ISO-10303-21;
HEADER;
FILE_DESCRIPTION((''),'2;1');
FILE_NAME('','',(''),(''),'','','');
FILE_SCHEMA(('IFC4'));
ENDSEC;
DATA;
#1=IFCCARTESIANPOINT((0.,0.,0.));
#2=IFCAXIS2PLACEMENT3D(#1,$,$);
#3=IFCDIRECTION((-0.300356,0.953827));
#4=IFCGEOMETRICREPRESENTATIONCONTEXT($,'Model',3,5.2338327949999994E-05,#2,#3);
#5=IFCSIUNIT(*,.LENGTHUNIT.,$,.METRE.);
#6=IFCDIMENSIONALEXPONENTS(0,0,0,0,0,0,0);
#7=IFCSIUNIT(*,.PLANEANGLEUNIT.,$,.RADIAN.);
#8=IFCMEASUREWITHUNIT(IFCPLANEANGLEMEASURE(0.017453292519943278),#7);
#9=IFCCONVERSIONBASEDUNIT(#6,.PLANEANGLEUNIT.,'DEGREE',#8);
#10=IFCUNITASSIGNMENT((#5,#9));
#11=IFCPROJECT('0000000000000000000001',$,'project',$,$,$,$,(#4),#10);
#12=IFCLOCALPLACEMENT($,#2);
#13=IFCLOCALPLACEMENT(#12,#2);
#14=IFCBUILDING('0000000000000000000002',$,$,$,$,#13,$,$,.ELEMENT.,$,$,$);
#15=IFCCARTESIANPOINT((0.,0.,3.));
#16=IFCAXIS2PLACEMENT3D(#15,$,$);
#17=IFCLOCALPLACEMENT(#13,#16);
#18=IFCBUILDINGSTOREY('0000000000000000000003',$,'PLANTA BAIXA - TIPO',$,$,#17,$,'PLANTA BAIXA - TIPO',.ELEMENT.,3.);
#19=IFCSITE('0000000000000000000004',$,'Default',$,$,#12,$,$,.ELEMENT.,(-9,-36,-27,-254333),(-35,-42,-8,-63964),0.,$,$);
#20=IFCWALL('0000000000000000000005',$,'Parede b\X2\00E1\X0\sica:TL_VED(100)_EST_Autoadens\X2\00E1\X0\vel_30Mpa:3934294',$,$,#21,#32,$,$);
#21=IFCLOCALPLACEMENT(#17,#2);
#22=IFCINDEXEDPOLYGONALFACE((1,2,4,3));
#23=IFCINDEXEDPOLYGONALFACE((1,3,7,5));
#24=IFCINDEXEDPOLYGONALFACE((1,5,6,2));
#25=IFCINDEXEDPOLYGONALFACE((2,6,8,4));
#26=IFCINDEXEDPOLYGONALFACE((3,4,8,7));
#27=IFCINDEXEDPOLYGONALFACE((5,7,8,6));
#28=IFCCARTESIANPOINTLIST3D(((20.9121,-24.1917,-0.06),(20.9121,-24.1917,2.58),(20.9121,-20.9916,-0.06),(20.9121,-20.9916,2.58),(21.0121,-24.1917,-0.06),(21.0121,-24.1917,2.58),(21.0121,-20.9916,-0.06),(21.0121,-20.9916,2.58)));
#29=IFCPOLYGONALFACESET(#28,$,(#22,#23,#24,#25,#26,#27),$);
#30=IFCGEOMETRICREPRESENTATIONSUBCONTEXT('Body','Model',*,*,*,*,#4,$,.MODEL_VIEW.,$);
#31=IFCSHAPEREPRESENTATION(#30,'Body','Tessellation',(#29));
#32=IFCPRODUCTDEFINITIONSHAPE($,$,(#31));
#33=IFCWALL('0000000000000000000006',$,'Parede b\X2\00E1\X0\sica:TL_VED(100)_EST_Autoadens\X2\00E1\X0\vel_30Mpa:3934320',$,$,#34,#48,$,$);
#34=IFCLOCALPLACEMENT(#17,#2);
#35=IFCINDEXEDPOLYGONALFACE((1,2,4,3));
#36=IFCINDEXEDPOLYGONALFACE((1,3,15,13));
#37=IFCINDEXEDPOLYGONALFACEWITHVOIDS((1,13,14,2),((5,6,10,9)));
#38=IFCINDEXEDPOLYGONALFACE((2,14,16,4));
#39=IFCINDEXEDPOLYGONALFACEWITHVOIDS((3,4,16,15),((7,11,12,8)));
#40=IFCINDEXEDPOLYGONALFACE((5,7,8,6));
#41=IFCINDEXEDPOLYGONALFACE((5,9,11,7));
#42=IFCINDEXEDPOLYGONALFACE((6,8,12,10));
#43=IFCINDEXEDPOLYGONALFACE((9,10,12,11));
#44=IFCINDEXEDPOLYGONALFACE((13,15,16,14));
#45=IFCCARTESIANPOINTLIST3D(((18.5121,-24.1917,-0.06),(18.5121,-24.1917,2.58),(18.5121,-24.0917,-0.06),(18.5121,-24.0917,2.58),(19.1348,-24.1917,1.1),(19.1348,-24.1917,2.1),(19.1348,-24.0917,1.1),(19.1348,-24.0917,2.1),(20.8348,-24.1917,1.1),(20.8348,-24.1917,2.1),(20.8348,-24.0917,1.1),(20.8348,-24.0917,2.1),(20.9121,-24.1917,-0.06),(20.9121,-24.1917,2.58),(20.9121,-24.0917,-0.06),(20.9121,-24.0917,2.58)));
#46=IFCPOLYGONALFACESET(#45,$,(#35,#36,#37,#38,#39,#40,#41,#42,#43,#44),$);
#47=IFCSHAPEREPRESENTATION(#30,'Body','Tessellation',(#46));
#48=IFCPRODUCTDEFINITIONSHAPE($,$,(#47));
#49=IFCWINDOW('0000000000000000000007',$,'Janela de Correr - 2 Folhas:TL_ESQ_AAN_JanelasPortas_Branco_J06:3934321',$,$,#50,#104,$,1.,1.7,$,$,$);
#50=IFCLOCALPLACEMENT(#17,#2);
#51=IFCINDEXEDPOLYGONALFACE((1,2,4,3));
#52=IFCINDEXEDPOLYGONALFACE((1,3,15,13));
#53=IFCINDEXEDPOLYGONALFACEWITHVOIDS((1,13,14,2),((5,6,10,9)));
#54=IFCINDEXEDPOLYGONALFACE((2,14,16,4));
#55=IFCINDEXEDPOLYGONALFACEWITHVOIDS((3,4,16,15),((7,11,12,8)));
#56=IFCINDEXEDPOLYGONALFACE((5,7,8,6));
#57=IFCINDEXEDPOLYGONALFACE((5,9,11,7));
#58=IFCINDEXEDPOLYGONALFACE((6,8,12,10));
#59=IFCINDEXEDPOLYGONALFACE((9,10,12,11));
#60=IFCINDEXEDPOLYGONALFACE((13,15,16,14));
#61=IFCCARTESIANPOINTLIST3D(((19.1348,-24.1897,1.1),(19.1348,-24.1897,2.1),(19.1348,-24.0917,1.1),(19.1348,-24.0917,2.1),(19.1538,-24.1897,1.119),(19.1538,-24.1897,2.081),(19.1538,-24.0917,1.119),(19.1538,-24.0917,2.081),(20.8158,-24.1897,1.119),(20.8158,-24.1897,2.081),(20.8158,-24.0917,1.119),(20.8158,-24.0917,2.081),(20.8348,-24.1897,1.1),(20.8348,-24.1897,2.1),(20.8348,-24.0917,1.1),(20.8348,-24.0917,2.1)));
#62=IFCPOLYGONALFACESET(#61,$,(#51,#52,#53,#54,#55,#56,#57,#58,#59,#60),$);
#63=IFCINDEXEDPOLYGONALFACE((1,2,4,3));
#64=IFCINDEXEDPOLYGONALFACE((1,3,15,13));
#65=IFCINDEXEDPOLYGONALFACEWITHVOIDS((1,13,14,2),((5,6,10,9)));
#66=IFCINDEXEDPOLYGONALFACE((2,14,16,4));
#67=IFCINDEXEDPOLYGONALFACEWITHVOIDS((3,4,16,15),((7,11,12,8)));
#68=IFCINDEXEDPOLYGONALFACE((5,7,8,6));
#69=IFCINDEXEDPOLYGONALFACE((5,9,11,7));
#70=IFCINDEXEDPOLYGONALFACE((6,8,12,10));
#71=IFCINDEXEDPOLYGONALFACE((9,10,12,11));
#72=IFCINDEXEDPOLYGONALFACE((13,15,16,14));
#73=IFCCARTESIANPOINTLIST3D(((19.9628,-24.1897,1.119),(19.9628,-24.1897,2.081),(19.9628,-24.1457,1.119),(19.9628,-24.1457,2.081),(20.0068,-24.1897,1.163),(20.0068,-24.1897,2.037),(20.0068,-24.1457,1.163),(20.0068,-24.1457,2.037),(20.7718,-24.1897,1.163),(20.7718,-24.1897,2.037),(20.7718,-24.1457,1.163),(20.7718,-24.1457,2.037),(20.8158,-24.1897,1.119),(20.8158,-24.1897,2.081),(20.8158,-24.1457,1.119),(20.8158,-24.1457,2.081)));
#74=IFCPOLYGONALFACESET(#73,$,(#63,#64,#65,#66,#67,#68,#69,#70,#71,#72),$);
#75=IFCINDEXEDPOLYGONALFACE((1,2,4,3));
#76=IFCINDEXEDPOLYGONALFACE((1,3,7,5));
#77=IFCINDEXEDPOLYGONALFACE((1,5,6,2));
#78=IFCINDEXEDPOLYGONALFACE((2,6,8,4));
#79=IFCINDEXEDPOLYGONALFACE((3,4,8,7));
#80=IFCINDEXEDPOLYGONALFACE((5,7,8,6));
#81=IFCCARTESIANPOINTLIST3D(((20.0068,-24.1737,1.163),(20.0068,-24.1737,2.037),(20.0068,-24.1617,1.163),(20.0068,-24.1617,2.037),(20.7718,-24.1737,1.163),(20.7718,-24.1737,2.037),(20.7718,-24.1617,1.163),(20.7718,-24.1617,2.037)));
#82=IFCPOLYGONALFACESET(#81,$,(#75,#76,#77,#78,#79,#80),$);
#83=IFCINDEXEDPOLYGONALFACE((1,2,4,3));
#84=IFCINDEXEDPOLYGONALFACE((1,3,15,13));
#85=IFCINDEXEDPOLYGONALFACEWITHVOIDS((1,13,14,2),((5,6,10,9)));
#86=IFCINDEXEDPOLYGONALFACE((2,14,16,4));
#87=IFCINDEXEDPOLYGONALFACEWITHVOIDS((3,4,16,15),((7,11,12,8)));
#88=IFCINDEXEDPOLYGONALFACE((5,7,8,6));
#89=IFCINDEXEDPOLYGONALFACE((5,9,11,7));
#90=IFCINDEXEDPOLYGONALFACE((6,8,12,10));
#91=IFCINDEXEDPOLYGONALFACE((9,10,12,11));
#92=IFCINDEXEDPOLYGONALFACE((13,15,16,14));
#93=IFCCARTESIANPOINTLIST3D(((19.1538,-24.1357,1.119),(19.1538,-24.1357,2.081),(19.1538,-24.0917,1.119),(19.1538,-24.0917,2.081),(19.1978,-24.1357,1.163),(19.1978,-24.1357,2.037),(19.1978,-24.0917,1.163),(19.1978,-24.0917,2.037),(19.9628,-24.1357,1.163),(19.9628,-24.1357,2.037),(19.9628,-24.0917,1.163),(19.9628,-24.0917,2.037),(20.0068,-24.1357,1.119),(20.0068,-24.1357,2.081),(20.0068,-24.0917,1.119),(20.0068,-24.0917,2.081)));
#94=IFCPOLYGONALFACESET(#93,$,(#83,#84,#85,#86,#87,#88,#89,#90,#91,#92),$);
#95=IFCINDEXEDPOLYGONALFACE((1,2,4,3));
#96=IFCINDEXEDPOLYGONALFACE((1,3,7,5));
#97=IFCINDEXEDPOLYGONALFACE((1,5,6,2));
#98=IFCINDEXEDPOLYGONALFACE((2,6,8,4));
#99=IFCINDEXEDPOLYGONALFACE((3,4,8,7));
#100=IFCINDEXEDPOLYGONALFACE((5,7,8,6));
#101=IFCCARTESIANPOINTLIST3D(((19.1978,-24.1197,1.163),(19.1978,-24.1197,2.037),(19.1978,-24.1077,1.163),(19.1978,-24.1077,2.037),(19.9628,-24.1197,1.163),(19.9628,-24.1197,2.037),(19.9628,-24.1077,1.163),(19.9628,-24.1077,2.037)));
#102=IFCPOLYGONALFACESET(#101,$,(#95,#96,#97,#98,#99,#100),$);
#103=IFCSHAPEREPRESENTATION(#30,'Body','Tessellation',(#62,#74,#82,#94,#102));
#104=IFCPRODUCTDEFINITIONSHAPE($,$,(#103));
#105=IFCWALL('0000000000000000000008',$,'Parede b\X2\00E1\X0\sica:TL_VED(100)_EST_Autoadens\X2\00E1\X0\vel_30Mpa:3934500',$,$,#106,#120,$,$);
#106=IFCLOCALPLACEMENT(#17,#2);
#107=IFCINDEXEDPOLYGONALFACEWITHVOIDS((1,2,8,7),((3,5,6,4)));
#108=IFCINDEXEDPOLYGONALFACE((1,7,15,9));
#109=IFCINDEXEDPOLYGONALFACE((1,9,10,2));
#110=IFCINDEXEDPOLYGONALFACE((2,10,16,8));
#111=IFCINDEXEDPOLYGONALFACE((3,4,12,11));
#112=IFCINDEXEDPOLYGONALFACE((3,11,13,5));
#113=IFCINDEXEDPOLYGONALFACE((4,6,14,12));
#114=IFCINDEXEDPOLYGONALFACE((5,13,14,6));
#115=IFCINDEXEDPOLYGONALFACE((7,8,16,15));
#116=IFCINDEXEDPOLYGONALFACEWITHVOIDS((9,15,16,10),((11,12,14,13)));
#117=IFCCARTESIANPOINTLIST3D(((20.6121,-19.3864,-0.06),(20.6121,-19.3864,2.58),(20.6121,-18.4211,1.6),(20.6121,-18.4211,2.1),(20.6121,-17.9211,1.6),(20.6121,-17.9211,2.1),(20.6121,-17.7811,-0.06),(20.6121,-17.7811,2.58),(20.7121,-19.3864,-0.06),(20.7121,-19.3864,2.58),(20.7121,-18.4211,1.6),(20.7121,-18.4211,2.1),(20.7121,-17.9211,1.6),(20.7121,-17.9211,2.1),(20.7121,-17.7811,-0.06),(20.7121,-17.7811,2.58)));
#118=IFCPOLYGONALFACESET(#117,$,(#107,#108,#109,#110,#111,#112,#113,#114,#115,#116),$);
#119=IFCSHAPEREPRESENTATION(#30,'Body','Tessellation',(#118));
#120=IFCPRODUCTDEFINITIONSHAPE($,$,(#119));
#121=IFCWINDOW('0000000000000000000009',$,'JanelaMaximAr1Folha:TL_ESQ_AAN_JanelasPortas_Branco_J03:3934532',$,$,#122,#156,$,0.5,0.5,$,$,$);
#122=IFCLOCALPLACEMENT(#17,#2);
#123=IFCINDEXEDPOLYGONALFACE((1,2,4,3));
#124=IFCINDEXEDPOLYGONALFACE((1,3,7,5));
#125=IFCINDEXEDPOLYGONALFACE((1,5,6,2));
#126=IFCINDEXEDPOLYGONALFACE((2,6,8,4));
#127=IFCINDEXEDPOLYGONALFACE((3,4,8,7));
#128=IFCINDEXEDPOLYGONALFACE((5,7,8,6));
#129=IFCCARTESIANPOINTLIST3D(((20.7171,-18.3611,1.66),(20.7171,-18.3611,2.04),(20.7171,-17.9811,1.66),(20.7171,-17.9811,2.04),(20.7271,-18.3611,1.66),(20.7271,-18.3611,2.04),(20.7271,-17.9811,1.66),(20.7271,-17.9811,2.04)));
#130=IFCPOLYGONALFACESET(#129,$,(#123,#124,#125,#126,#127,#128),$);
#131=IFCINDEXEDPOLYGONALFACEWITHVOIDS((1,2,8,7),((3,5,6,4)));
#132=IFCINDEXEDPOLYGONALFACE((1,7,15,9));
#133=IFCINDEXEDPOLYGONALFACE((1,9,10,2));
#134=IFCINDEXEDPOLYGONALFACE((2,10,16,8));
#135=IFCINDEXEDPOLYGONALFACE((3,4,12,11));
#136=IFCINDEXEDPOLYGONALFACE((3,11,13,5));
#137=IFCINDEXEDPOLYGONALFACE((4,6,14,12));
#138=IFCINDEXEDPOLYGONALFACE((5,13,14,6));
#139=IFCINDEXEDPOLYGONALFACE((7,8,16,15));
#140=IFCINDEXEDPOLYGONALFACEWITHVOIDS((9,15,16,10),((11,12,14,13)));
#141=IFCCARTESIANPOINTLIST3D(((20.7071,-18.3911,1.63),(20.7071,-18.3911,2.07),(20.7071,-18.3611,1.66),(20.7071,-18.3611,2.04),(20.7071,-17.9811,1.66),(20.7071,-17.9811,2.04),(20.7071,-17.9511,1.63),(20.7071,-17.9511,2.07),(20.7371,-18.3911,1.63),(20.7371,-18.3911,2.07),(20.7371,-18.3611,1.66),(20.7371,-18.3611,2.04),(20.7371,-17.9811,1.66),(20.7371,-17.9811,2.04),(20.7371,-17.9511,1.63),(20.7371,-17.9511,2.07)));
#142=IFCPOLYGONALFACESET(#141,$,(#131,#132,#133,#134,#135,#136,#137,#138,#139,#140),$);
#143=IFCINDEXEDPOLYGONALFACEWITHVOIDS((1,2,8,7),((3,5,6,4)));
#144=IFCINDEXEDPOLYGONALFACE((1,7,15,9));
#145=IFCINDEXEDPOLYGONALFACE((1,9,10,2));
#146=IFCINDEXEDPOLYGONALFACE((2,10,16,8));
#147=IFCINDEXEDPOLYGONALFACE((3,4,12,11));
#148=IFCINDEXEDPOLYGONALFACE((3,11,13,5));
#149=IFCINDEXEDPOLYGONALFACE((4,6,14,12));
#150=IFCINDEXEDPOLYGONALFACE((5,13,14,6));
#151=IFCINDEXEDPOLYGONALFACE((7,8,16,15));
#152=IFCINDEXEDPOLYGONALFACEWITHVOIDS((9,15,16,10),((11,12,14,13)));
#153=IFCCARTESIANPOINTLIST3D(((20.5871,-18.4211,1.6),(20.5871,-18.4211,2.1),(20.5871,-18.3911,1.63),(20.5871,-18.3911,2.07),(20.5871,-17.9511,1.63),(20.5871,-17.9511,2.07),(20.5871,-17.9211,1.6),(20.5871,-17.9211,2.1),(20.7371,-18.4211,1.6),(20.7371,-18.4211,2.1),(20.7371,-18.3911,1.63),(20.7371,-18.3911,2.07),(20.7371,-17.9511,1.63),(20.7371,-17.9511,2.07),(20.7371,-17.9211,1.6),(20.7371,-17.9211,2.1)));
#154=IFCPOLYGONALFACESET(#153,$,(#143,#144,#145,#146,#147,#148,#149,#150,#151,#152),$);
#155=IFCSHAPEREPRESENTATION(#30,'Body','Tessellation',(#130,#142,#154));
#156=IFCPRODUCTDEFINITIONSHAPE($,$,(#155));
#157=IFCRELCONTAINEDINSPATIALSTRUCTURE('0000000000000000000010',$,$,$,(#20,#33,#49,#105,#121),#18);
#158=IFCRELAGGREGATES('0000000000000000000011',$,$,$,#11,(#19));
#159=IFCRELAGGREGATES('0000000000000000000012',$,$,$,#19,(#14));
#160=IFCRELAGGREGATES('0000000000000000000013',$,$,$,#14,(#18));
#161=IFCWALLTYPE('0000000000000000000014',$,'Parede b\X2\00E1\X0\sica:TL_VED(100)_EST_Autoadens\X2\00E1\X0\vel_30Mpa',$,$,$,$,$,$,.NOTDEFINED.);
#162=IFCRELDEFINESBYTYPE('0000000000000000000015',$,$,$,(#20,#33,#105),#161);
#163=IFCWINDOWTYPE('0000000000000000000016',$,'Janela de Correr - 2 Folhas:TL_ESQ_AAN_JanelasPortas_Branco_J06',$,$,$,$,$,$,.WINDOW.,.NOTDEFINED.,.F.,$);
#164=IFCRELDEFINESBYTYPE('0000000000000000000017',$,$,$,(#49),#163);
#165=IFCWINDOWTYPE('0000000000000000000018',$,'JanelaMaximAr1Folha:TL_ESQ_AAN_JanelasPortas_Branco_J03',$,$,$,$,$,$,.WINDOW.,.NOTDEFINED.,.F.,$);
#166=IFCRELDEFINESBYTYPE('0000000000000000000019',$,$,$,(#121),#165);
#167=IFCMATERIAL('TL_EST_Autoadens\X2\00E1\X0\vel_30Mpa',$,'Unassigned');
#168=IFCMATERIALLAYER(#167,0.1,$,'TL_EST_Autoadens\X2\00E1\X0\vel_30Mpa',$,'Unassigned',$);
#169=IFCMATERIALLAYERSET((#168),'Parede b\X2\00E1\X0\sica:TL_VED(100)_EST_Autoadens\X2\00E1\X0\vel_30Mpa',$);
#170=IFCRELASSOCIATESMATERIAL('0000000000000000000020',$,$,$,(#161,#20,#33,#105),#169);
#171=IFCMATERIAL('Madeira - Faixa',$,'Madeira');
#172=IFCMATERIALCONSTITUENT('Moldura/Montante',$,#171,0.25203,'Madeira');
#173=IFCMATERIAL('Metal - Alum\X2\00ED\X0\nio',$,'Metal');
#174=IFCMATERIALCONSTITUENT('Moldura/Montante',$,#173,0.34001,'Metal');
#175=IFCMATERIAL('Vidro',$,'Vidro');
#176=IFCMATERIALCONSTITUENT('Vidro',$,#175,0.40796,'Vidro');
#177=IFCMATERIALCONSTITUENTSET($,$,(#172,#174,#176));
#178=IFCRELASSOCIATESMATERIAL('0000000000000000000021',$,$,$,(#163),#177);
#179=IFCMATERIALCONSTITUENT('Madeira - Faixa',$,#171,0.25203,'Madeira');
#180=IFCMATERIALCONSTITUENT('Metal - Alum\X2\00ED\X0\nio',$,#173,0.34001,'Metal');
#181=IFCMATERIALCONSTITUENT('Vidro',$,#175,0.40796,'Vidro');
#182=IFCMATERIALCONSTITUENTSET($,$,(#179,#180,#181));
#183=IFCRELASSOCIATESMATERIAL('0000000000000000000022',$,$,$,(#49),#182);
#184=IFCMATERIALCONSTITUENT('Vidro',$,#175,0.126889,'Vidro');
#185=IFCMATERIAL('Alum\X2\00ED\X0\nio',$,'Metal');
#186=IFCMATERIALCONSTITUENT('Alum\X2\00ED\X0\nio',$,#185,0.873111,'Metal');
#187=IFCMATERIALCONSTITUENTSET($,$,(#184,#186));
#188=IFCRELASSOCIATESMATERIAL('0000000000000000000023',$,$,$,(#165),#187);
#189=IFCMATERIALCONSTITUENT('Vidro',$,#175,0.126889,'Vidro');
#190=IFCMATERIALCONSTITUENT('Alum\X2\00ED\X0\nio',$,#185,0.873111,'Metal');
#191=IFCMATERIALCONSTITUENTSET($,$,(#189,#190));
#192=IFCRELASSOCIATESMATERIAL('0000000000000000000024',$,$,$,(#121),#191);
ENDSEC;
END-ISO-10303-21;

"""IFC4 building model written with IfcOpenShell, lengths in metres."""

from ifc_helpers import new_model, entity, si_unit, converted_unit, direction, frame, frame_2d, origin, origin_2d_with_axis, place, context, subcontext, project, spatial, polyline, rectangle, outline, extrude, source, transform, mapped, material, layer, layer_set, layer_usage, constituent, constituent_set, type_object, type_shapes, element, fill, save


model = new_model("IFC4")

# Units and contexts
model_context = context("Model", 3, precision=5.2338327949999994e-05, world=origin(), true_north=direction((-0.300356, 0.953827)))
body_context = subcontext(model_context, "Body", "Model", "MODEL_VIEW")
ifc_project = project(units=[si_unit("LENGTHUNIT", "METRE"), converted_unit("PLANEANGLEUNIT", "DEGREE", entity("IfcPlaneAngleMeasure", 0.017453292519943278), si_unit("PLANEANGLEUNIT", "RADIAN"), dimensions=[0, 0, 0, 0, 0, 0, 0])], contexts=[model_context])

# Site, building, storey
site_placement = place(None, origin())
site = spatial("IfcSite", under=ifc_project, at=site_placement, Name="Default", CompositionType="ELEMENT", RefLatitude=(-9, -36, -27, -254333), RefLongitude=(-35, -42, -8, -63964), RefElevation=0.0)
building_placement = place(site_placement, origin())
building = spatial("IfcBuilding", under=site, at=building_placement, CompositionType="ELEMENT")
storey_placement = place(building_placement, frame((0.0, 0.0, 3.0)))
storey = spatial("IfcBuildingStorey", under=building, at=storey_placement, Name="PLANTA BAIXA - TIPO", LongName="PLANTA BAIXA - TIPO", CompositionType="ELEMENT", Elevation=3.0)

# Wall
ifc_material_1 = material(Name="TL_EST_Autoadensável_30Mpa", Category="Unassigned")
ifc_layer_1 = layer(ifc_material_1, 0.1, Name="TL_EST_Autoadensável_30Mpa", Category="Unassigned")
ifc_layer_set_1 = layer_set([ifc_layer_1], Name="Parede básica:TL_VED(100)_EST_Autoadensável_30Mpa")
ifc_layer_usage_1 = layer_usage(ifc_layer_set_1, "AXIS2", "NEGATIVE", 0.05)
wall_type_1 = type_object("IfcWallType", Name="Parede básica:TL_VED(100)_EST_Autoadensável_30Mpa", PredefinedType="NOTDEFINED", material=ifc_layer_set_1)
wall_1_placement = place(storey_placement, frame((20.9621, -24.1917, -0.06), z_axis=(0.0, 0.0, 1.0), x_axis=(0.0, 1.0, 0.0)))
element("IfcWall", 1, at=wall_1_placement, inside=storey, type_object=wall_type_1, material=ifc_layer_usage_1, Name="Parede básica:TL_VED(100)_EST_Autoadensável_30Mpa:3934294", context=body_context, shape_type="SweptSolid", body=[
    extrude(rectangle(XDim=3.2001, YDim=0.1, at=frame_2d((1.6001, 0.0), x_axis=(-1.0, 0.0))), origin(), (0.0, 0.0, 1.0), 2.64),
])

# Walls, openings, windows
ifc_layer_usage_2 = layer_usage(ifc_layer_set_1, "AXIS2", "NEGATIVE", 0.05)
wall_2_placement = place(storey_placement, frame((20.9121, -24.1417, -0.06), z_axis=(0.0, 0.0, 1.0), x_axis=(-1.0, 0.0, 0.0)))
wall_2 = element("IfcWall", 2, at=wall_2_placement, inside=storey, type_object=wall_type_1, material=ifc_layer_usage_2, Name="Parede básica:TL_VED(100)_EST_Autoadensável_30Mpa:3934320", context=body_context, shape_type="SweptSolid", body=[
    extrude(rectangle(XDim=2.4, YDim=0.1, at=frame_2d((1.2, 0.0), x_axis=(-1.0, 0.0))), origin(), (0.0, 0.0, 1.0), 2.64),
])
opening_1_placement = place(wall_2_placement, frame((0.0774, -0.05, 1.16)))
opening_1 = element("IfcOpeningElement", 3, at=opening_1_placement, cuts=wall_2, PredefinedType="OPENING", context=body_context, shape_type="SweptSolid", body=[
    extrude(rectangle(XDim=1.0, YDim=1.7, at=frame_2d((0.5, 0.85), x_axis=(-1.0, 0.0))), frame((0.0, 0.0, 0.0), z_axis=(0.0, 1.0, 0.0), x_axis=(0.0, 0.0, 1.0)), (0.0, 0.0, 1.0), 0.1),
])
ifc_material_2 = material(Name="Madeira - Faixa", Category="Madeira")
ifc_constituent_1 = constituent(ifc_material_2, Name="Madeira - Faixa", Category="Madeira", fraction=0.25203)
ifc_material_3 = material(Name="Metal - Alumínio", Category="Metal")
ifc_constituent_2 = constituent(ifc_material_3, Name="Metal - Alumínio", Category="Metal", fraction=0.34001)
ifc_material_4 = material(Name="Vidro", Category="Vidro")
ifc_constituent_3 = constituent(ifc_material_4, Name="Vidro", Category="Vidro", fraction=0.40796)
ifc_constituent_set_1 = constituent_set(constituents=[ifc_constituent_1, ifc_constituent_2, ifc_constituent_3])
ifc_constituent_4 = constituent(ifc_material_2, Name="Moldura/Montante", Category="Madeira", fraction=0.25203)
ifc_constituent_5 = constituent(ifc_material_3, Name="Moldura/Montante", Category="Metal", fraction=0.34001)
ifc_constituent_6 = constituent(ifc_material_4, Name="Vidro", Category="Vidro", fraction=0.40796)
ifc_constituent_set_2 = constituent_set(constituents=[ifc_constituent_4, ifc_constituent_5, ifc_constituent_6])
window_type_1 = type_object("IfcWindowType", Name="Janela de Correr - 2 Folhas:TL_ESQ_AAN_JanelasPortas_Branco_J06", ParameterTakesPrecedence=False, PartitioningType="NOTDEFINED", PredefinedType="WINDOW", material=ifc_constituent_set_2)
shared_shape_1 = source(origin(), body_context, "Body", "SweptSolid", [
    extrude(outline(polyline([(-0.85, -0.5), (0.85, -0.5), (0.85, 0.5), (-0.85, 0.5), (-0.85, -0.5)]), holes=[polyline([(-0.831, -0.481), (-0.831, 0.481), (0.831, 0.481), (0.831, -0.481), (-0.831, -0.481)])]), frame((0.85, 0.124, 0.5), z_axis=(0.0, -1.0, 0.0), x_axis=(-1.0, 0.0, 0.0)), (0.0, 0.0, 1.0), 0.098),
    extrude(outline(polyline([(-0.4265, -0.481), (0.4265, -0.481), (0.4265, 0.481), (-0.4265, 0.481), (-0.4265, -0.481)]), holes=[polyline([(-0.3825, -0.437), (-0.3825, 0.437), (0.3825, 0.437), (0.3825, -0.437), (-0.3825, -0.437)])]), frame((0.4455, 0.124, 0.5), z_axis=(0.0, -1.0, 0.0), x_axis=(-1.0, 0.0, 0.0)), (0.0, 0.0, 1.0), 0.044),
    extrude(rectangle(XDim=0.765, YDim=0.012, at=origin_2d_with_axis()), frame((0.4455, 0.102, 0.063), z_axis=(0.0, 0.0, 1.0), x_axis=(-1.0, 0.0, 0.0)), (0.0, 0.0, 1.0), 0.874),
    extrude(outline(polyline([(-0.481, -0.4265), (0.481, -0.4265), (0.481, 0.4265), (-0.481, 0.4265), (-0.481, -0.4265)]), holes=[polyline([(-0.437, -0.3825), (-0.437, 0.3825), (0.437, 0.3825), (0.437, -0.3825), (-0.437, -0.3825)])]), frame((1.2545, 0.07, 0.5), z_axis=(0.0, -1.0, 0.0), x_axis=(0.0, 0.0, -1.0)), (0.0, 0.0, 1.0), 0.044),
    extrude(rectangle(XDim=0.765, YDim=0.012, at=origin_2d_with_axis()), frame((1.2545, 0.048, 0.063), z_axis=(0.0, 0.0, 1.0), x_axis=(-1.0, 0.0, 0.0)), (0.0, 0.0, 1.0), 0.874),
])
type_shapes(window_type_1, [shared_shape_1])
window_1_placement = place(opening_1_placement, frame((0.0, -0.026, 0.0)))
window_1 = element("IfcWindow", 4, at=window_1_placement, inside=storey, type_object=window_type_1, material=ifc_constituent_set_1, Name="Janela de Correr - 2 Folhas:TL_ESQ_AAN_JanelasPortas_Branco_J06:3934321", OverallHeight=1.0, OverallWidth=1.7, context=body_context, shape_type="MappedRepresentation", body=[
    mapped(shared_shape_1, transform((0.0, 0.0, 0.0), scale=1.0)),
])
fill(opening_1, window_1)
ifc_layer_usage_3 = layer_usage(ifc_layer_set_1, "AXIS2", "POSITIVE", -0.05)
wall_3_placement = place(storey_placement, frame((20.6621, -19.3864, -0.06), z_axis=(0.0, 0.0, 1.0), x_axis=(0.0, 1.0, 0.0)))
wall_3 = element("IfcWall", 5, at=wall_3_placement, inside=storey, type_object=wall_type_1, material=ifc_layer_usage_3, Name="Parede básica:TL_VED(100)_EST_Autoadensável_30Mpa:3934500", context=body_context, shape_type="SweptSolid", body=[
    extrude(rectangle(XDim=1.6052, YDim=0.1, at=frame_2d((0.8026, 0.0), x_axis=(-1.0, 0.0))), origin(), (0.0, 0.0, 1.0), 2.64),
])
opening_2_placement = place(wall_3_placement, frame((0.9652, -0.05, 1.66)))
opening_2 = element("IfcOpeningElement", 6, at=opening_2_placement, cuts=wall_3, PredefinedType="OPENING", context=body_context, shape_type="SweptSolid", body=[
    extrude(rectangle(XDim=0.5, YDim=0.5, at=frame_2d((0.25, 0.25), x_axis=(1.0, 0.0))), frame((0.0, 0.0, 0.0), z_axis=(0.0, 1.0, 0.0), x_axis=(0.0, 0.0, 1.0)), (0.0, 0.0, 1.0), 0.1),
])
ifc_constituent_7 = constituent(ifc_material_4, Name="Vidro", Category="Vidro", fraction=0.126889)
ifc_material_5 = material(Name="Alumínio", Category="Metal")
ifc_constituent_8 = constituent(ifc_material_5, Name="Alumínio", Category="Metal", fraction=0.873111)
ifc_constituent_set_3 = constituent_set(constituents=[ifc_constituent_7, ifc_constituent_8])
ifc_constituent_9 = constituent(ifc_material_4, Name="Vidro", Category="Vidro", fraction=0.126889)
ifc_constituent_10 = constituent(ifc_material_5, Name="Alumínio", Category="Metal", fraction=0.873111)
ifc_constituent_set_4 = constituent_set(constituents=[ifc_constituent_9, ifc_constituent_10])
window_type_2 = type_object("IfcWindowType", Name="JanelaMaximAr1Folha:TL_ESQ_AAN_JanelasPortas_Branco_J03", ParameterTakesPrecedence=False, PartitioningType="NOTDEFINED", PredefinedType="WINDOW", material=ifc_constituent_set_4)
shared_shape_2 = source(origin(), body_context, "Body", "SweptSolid", [
    extrude(rectangle(XDim=0.38, YDim=0.01, at=frame_2d((0.0, 0.0), x_axis=(1.0, 0.0))), frame((0.25, -0.01, 0.06)), (0.0, 0.0, 1.0), 0.38),
    extrude(outline(polyline([(-0.22, -0.22), (0.22, -0.22), (0.22, 0.22), (-0.22, 0.22), (-0.22, -0.22)]), holes=[polyline([(0.19, 0.19), (0.19, -0.19), (-0.19, -0.19), (-0.19, 0.19), (0.19, 0.19)])]), frame((0.25, 0.005, 0.25), z_axis=(0.0, -1.0, 0.0), x_axis=(0.0, 0.0, -1.0)), (0.0, 0.0, 1.0), 0.03),
    extrude(outline(polyline([(-0.25, -0.25), (0.25, -0.25), (0.25, 0.25), (-0.25, 0.25), (-0.25, -0.25)]), holes=[polyline([(-0.22, -0.22), (-0.22, 0.22), (0.22, 0.22), (0.22, -0.22), (-0.22, -0.22)])]), frame((0.25, 0.125, 0.25), z_axis=(0.0, -1.0, 0.0), x_axis=(0.0, 0.0, -1.0)), (0.0, 0.0, 1.0), 0.15),
])
type_shapes(window_type_2, [shared_shape_2])
window_2_placement = place(opening_2_placement, origin())
window_2 = element("IfcWindow", 7, at=window_2_placement, inside=storey, type_object=window_type_2, material=ifc_constituent_set_3, Name="JanelaMaximAr1Folha:TL_ESQ_AAN_JanelasPortas_Branco_J03:3934532", OverallHeight=0.5, OverallWidth=0.5, context=body_context, shape_type="MappedRepresentation", body=[
    mapped(shared_shape_2, transform((0.0, 0.0, 0.0), scale=1.0)),
])
fill(opening_2, window_2)

save(model, "model.ifc")
